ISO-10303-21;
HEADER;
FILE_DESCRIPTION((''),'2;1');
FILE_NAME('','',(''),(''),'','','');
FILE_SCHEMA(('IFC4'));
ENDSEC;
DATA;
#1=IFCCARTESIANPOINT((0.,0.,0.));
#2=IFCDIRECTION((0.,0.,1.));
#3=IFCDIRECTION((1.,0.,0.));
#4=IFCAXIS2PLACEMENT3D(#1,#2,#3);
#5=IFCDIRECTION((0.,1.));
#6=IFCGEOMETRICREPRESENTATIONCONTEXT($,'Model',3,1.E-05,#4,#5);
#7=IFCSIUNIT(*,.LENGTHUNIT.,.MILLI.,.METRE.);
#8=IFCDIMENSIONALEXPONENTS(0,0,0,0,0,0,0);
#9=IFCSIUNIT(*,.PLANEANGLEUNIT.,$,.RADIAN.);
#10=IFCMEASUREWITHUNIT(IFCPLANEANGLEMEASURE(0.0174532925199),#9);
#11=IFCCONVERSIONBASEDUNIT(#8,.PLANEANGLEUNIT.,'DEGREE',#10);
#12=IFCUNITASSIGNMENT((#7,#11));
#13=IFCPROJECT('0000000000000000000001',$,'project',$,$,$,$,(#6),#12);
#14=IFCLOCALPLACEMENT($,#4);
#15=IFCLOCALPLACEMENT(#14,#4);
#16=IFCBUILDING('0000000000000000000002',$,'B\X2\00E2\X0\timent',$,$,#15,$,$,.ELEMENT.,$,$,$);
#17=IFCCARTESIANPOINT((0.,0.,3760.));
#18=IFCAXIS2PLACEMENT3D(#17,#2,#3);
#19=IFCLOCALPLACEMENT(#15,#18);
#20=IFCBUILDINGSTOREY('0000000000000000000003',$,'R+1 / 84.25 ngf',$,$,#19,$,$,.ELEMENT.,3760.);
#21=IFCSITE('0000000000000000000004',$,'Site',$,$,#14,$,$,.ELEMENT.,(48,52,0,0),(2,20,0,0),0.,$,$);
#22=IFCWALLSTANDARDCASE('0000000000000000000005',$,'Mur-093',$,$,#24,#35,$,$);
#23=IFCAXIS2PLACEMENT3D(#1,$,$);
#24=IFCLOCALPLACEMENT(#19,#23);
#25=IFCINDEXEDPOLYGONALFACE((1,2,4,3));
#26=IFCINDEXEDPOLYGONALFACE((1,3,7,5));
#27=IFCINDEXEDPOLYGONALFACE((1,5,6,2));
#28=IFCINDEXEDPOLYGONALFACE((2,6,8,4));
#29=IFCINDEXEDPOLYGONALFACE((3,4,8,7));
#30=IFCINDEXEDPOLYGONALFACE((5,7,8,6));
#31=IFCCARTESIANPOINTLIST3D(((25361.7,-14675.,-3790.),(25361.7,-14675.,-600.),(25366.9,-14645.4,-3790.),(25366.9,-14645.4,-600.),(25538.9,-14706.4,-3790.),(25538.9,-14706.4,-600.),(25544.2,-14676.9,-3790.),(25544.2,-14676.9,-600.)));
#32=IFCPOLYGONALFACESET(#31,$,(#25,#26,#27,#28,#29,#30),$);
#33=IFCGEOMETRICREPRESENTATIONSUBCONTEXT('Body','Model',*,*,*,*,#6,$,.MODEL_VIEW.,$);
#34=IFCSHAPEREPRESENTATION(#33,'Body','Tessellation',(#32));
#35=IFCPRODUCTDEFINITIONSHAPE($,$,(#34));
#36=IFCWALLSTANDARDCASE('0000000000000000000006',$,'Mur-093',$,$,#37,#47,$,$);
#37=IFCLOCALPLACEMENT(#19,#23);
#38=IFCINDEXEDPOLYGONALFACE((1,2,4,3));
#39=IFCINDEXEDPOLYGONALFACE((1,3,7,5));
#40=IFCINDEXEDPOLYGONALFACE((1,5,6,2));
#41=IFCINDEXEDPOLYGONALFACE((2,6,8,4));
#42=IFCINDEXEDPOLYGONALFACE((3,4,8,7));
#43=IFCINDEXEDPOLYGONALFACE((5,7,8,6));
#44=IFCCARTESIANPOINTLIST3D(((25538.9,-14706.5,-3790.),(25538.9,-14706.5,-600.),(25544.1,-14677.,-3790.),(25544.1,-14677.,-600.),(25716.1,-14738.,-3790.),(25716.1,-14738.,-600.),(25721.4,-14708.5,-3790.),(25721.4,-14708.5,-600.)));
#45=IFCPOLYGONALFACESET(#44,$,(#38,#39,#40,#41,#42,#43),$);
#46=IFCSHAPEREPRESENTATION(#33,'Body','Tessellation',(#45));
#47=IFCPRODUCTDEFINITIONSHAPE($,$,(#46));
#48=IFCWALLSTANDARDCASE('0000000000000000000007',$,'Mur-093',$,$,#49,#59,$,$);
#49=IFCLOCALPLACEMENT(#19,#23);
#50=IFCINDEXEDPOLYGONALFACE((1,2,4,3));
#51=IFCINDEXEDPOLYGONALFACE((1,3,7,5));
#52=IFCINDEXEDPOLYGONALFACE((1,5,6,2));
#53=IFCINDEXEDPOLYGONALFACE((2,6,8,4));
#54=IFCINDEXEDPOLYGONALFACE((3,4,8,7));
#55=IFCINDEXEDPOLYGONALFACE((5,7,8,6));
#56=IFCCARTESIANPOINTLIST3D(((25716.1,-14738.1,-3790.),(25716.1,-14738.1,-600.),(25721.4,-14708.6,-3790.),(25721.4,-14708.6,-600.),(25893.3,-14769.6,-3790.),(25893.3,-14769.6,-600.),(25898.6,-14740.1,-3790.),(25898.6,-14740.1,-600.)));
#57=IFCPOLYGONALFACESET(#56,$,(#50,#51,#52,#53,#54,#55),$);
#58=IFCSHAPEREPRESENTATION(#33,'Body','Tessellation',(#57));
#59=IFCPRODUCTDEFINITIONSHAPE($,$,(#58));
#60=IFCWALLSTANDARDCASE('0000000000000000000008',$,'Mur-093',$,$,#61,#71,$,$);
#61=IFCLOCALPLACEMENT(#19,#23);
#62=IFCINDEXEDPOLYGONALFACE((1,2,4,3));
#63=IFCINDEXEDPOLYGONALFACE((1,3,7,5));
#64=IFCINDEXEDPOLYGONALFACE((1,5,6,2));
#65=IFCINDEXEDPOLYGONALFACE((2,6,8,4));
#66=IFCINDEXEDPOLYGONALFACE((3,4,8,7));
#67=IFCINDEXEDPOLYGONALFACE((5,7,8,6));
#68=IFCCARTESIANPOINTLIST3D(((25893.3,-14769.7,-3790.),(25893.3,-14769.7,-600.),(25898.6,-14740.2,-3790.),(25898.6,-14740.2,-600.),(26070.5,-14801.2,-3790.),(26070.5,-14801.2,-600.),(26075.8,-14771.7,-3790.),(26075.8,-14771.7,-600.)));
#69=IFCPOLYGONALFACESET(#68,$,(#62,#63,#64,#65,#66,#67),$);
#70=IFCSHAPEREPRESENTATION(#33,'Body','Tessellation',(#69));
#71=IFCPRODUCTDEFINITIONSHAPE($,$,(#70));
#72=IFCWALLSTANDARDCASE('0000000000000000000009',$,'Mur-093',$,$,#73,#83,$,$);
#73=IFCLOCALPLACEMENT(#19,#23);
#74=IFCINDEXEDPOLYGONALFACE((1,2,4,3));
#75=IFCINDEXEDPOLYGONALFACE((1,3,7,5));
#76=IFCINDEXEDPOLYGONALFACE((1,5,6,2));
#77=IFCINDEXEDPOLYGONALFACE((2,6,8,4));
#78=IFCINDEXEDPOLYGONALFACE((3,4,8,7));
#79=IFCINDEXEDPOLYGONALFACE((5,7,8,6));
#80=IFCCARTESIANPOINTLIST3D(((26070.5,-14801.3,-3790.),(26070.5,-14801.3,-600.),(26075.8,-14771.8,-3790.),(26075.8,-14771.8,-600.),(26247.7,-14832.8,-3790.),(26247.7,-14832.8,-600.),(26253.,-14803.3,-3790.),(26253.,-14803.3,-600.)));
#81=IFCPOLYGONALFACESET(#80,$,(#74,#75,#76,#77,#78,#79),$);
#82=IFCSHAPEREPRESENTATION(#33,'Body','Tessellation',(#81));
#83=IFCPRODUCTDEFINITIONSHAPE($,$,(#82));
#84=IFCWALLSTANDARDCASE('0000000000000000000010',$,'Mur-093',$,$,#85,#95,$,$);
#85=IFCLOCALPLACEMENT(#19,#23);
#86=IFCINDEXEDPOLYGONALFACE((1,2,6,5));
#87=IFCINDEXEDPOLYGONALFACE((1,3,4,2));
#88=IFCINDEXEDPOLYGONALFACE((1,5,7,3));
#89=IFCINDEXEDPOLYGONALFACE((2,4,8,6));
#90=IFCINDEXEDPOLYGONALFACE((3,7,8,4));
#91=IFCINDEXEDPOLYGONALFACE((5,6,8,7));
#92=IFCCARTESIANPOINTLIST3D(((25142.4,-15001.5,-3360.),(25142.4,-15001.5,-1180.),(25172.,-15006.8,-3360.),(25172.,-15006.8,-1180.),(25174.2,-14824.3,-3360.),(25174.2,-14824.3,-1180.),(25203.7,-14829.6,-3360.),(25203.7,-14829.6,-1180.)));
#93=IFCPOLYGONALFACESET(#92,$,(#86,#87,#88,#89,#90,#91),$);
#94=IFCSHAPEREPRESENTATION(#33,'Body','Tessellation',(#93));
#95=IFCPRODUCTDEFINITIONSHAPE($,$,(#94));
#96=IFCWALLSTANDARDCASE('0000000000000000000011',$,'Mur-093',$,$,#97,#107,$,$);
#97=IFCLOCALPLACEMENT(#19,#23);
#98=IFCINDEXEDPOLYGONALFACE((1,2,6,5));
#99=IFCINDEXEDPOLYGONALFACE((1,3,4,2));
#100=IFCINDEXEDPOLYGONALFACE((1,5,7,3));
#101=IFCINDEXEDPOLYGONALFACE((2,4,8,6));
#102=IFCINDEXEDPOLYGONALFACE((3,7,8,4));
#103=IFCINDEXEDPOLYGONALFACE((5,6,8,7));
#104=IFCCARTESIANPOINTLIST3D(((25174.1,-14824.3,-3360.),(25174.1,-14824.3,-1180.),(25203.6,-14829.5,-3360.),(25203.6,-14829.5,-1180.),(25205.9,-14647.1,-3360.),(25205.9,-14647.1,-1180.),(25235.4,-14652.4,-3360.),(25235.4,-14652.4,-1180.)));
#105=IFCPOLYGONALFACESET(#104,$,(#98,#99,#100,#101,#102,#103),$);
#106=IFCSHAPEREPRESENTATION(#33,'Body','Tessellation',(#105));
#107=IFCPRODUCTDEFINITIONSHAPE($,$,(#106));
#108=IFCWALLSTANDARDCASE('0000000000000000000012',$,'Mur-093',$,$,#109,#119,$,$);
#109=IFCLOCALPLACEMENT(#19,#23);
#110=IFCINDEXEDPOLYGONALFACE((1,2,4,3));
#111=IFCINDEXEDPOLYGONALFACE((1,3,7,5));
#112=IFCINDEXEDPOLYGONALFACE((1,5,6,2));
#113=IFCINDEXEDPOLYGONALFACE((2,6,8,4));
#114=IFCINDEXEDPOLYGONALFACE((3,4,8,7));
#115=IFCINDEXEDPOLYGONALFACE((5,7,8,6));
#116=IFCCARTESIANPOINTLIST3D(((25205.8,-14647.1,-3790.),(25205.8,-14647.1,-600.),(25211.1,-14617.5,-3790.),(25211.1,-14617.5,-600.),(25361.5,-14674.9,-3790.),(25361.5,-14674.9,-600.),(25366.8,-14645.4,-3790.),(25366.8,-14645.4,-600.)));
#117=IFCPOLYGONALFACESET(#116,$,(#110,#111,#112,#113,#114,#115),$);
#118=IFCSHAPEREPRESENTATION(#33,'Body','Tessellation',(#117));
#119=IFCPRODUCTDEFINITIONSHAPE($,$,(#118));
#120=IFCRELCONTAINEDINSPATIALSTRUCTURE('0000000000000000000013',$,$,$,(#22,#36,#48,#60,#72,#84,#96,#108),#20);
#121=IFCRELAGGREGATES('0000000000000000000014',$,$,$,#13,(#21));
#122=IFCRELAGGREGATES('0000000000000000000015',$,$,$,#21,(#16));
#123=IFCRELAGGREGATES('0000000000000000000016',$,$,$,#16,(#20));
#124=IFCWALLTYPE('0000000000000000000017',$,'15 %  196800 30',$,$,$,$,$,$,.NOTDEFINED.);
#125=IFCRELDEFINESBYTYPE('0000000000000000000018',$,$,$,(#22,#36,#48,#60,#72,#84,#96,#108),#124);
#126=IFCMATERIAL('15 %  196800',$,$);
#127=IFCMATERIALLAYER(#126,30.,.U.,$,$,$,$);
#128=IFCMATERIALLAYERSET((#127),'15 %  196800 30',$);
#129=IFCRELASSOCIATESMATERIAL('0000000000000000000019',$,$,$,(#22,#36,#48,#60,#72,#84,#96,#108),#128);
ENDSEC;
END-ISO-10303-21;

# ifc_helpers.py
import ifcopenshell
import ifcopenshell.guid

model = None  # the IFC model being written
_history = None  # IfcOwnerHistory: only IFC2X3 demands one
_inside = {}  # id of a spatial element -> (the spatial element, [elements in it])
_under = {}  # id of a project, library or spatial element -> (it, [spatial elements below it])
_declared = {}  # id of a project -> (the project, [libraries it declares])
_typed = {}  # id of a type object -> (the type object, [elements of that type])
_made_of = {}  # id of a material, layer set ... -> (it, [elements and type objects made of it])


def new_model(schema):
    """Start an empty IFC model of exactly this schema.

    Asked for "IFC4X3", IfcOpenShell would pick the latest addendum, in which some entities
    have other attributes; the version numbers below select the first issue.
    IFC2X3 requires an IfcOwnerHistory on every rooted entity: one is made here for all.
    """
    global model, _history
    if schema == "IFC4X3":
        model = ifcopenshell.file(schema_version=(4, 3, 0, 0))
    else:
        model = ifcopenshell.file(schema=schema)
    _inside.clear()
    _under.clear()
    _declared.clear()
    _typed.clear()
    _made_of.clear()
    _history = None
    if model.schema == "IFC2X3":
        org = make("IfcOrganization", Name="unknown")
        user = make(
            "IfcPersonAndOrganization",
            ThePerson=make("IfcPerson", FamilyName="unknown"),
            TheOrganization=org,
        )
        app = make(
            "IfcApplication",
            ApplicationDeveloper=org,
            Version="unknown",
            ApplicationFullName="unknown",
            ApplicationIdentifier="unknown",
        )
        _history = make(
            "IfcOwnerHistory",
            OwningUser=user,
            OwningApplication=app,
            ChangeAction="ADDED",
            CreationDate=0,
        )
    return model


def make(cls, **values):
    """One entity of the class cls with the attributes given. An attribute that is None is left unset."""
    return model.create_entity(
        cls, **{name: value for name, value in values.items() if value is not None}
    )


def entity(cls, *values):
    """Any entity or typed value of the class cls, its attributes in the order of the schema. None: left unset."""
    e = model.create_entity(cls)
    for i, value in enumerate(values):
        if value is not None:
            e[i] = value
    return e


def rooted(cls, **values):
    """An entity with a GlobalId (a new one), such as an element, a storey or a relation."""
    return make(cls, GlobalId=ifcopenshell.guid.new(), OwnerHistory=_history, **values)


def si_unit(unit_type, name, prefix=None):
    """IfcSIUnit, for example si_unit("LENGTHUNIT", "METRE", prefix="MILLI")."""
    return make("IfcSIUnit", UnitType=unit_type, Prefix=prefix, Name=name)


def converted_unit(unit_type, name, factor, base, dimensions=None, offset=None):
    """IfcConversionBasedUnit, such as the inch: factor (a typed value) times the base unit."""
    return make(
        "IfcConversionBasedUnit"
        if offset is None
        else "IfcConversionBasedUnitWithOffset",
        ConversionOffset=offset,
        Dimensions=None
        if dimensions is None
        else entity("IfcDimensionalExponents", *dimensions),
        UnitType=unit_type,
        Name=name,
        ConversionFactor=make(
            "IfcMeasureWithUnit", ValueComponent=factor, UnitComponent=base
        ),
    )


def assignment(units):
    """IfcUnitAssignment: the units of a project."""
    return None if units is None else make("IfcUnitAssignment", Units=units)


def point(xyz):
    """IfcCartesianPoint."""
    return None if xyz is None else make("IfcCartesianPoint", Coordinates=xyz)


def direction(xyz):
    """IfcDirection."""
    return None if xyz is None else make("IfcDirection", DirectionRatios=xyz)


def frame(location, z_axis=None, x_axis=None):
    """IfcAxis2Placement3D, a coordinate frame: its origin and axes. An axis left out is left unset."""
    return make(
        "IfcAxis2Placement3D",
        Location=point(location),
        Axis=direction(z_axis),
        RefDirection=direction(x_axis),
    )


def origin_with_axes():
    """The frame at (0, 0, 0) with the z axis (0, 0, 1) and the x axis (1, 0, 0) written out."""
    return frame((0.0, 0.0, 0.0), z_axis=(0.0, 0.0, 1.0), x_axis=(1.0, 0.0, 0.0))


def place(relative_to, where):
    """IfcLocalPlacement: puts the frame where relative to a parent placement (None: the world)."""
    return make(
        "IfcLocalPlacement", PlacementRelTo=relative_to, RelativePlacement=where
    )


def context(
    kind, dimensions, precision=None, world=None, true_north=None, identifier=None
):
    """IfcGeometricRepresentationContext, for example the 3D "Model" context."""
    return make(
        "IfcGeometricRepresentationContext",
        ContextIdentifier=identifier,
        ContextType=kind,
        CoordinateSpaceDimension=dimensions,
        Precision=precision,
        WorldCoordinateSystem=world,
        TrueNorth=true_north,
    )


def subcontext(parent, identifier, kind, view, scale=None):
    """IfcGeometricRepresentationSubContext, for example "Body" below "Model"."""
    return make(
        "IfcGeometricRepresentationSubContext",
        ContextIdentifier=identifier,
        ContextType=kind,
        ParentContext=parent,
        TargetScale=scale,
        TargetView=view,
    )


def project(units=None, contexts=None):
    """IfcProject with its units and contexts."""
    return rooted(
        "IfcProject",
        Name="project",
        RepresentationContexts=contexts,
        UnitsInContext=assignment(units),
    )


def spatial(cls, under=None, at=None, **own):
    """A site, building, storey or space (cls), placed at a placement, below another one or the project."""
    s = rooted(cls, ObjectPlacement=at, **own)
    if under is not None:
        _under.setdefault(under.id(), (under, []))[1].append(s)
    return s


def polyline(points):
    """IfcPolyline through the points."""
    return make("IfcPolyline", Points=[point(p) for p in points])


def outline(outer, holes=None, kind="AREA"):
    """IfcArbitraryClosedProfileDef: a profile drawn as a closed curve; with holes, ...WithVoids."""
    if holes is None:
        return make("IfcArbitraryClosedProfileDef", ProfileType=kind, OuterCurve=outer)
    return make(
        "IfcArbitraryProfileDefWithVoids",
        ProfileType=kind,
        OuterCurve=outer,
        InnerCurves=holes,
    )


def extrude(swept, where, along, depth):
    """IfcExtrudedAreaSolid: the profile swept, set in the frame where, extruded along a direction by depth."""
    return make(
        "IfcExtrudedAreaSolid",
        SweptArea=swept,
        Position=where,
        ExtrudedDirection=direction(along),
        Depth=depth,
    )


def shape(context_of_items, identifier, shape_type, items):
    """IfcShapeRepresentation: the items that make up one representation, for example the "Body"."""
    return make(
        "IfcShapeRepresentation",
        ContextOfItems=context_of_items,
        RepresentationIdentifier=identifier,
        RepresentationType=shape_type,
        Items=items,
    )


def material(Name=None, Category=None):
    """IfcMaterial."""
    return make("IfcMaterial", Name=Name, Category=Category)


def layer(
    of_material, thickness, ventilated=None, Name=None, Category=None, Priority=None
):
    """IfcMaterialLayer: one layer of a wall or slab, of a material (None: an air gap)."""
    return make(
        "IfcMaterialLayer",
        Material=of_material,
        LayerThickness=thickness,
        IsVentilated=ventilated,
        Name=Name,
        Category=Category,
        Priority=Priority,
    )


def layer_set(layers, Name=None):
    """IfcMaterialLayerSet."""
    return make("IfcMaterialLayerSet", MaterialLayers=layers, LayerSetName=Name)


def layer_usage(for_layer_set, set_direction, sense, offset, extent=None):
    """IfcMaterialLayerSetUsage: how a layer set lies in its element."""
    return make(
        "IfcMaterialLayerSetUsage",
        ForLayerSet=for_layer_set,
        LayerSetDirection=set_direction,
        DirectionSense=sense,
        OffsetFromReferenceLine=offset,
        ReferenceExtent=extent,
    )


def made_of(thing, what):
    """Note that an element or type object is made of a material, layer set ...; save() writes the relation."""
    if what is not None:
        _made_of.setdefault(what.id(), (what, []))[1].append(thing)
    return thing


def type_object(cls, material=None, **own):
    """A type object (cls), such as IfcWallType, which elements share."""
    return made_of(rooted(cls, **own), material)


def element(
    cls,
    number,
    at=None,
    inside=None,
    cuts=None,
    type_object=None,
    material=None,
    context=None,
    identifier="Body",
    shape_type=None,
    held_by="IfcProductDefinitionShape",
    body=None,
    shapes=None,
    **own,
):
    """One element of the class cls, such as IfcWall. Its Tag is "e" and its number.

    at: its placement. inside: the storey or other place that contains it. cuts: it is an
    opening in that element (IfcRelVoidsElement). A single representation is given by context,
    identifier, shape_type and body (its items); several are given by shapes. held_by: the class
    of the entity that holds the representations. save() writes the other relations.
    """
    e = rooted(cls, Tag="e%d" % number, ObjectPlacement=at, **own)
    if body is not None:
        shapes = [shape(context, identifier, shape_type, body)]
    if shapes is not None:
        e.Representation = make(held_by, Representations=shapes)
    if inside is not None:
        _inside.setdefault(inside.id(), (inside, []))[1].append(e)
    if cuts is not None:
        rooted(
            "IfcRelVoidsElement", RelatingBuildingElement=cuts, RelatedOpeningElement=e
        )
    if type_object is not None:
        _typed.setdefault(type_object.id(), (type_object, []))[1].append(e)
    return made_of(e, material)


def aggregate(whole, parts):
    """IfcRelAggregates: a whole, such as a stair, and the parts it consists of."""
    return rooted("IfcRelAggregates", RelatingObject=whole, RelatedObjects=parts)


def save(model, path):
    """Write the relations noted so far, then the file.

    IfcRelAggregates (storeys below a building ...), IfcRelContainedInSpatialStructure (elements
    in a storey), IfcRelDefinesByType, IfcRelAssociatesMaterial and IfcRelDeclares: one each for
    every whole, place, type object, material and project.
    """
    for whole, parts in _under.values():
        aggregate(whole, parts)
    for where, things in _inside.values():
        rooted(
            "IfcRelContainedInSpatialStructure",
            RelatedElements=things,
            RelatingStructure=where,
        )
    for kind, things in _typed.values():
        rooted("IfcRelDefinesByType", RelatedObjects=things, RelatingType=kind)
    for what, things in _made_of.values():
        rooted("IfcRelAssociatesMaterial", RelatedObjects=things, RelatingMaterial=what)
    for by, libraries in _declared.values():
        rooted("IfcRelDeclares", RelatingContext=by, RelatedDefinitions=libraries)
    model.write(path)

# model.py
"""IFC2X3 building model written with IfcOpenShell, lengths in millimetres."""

from ifc_helpers import new_model, entity, si_unit, converted_unit, direction, frame, origin_with_axes, place, context, subcontext, project, spatial, polyline, outline, extrude, material, layer, layer_set, layer_usage, type_object, element, save


model = new_model("IFC2X3")

# Units and contexts
model_context = context("Model", 3, precision=1e-05, world=origin_with_axes(), true_north=direction((0.0, 1.0)))
body_context = subcontext(model_context, "Body", "Model", "MODEL_VIEW")
ifc_project = project(units=[si_unit("LENGTHUNIT", "METRE", prefix="MILLI"), converted_unit("PLANEANGLEUNIT", "DEGREE", entity("IfcPlaneAngleMeasure", 0.0174532925199), si_unit("PLANEANGLEUNIT", "RADIAN"), dimensions=[0, 0, 0, 0, 0, 0, 0])], contexts=[model_context])

# Site, building, storey
site_placement = place(None, origin_with_axes())
site = spatial("IfcSite", under=ifc_project, at=site_placement, Name="Site", CompositionType="ELEMENT", RefLatitude=(48, 52, 0, 0), RefLongitude=(2, 20, 0, 0), RefElevation=0.0)
building_placement = place(site_placement, origin_with_axes())
building = spatial("IfcBuilding", under=site, at=building_placement, Name="Bâtiment", CompositionType="ELEMENT")
storey_placement = place(building_placement, frame((0.0, 0.0, 3760.0), z_axis=(0.0, 0.0, 1.0), x_axis=(1.0, 0.0, 0.0)))
storey = spatial("IfcBuildingStorey", under=building, at=storey_placement, Name="R+1 / 84.25 ngf", CompositionType="ELEMENT", Elevation=3760.0)

# Walls
ifc_material = material(Name="15 %  196800")
ifc_layer = layer(ifc_material, 30.0, ventilated="UNKNOWN")
ifc_layer_set = layer_set([ifc_layer], Name="15 %  196800 30")
wall_type = type_object("IfcWallType", Name="15 %  196800 30", PredefinedType="NOTDEFINED")
ifc_layer_usage_1 = layer_usage(ifc_layer_set, "AXIS2", "NEGATIVE", 30.0)
wall_1_placement = place(storey_placement, frame((25544.2, -14676.9, -3790.0), z_axis=(0.0, 0.0, 1.0), x_axis=(-0.984592, 0.174869, 0.0)))
element("IfcWallStandardCase", 1, at=wall_1_placement, inside=storey, type_object=wall_type, material=ifc_layer_usage_1, Name="Mur-093", context=body_context, shape_type="SweptSolid", body=[
    extrude(outline(polyline([(0.0, 0.0), (180.0, 0.0), (180.0, 30.0), (0.0, 30.0), (0.0, 0.0)])), origin_with_axes(), (0.0, 0.0, 1.0), 3190.0),
])
ifc_layer_usage_2 = layer_usage(ifc_layer_set, "AXIS2", "NEGATIVE", 30.0)
wall_2_placement = place(storey_placement, frame((25721.4, -14708.5, -3790.0), z_axis=(0.0, 0.0, 1.0), x_axis=(-0.984592, 0.174869, 0.0)))
element("IfcWallStandardCase", 2, at=wall_2_placement, inside=storey, type_object=wall_type, material=ifc_layer_usage_2, Name="Mur-093", context=body_context, shape_type="SweptSolid", body=[
    extrude(outline(polyline([(0.0, 0.0), (180.0, 0.0), (180.0, 30.0), (0.0, 30.0), (0.0, 0.0)])), origin_with_axes(), (0.0, 0.0, 1.0), 3190.0),
])
ifc_layer_usage_3 = layer_usage(ifc_layer_set, "AXIS2", "NEGATIVE", 30.0)
wall_3_placement = place(storey_placement, frame((25898.6, -14740.1, -3790.0), z_axis=(0.0, 0.0, 1.0), x_axis=(-0.984592, 0.174869, 0.0)))
element("IfcWallStandardCase", 3, at=wall_3_placement, inside=storey, type_object=wall_type, material=ifc_layer_usage_3, Name="Mur-093", context=body_context, shape_type="SweptSolid", body=[
    extrude(outline(polyline([(0.0, 0.0), (180.0, 0.0), (180.0, 30.0), (0.0, 30.0), (0.0, 0.0)])), origin_with_axes(), (0.0, 0.0, 1.0), 3190.0),
])
ifc_layer_usage_4 = layer_usage(ifc_layer_set, "AXIS2", "NEGATIVE", 30.0)
wall_4_placement = place(storey_placement, frame((26075.8, -14771.7, -3790.0), z_axis=(0.0, 0.0, 1.0), x_axis=(-0.984592, 0.174869, 0.0)))
element("IfcWallStandardCase", 4, at=wall_4_placement, inside=storey, type_object=wall_type, material=ifc_layer_usage_4, Name="Mur-093", context=body_context, shape_type="SweptSolid", body=[
    extrude(outline(polyline([(0.0, 0.0), (180.0, 0.0), (180.0, 30.0), (0.0, 30.0), (0.0, 0.0)])), origin_with_axes(), (0.0, 0.0, 1.0), 3190.0),
])
ifc_layer_usage_5 = layer_usage(ifc_layer_set, "AXIS2", "NEGATIVE", 30.0)
wall_5_placement = place(storey_placement, frame((26253.0, -14803.3, -3790.0), z_axis=(0.0, 0.0, 1.0), x_axis=(-0.984592, 0.174869, 0.0)))
element("IfcWallStandardCase", 5, at=wall_5_placement, inside=storey, type_object=wall_type, material=ifc_layer_usage_5, Name="Mur-093", context=body_context, shape_type="SweptSolid", body=[
    extrude(outline(polyline([(0.0, 0.0), (180.0, 0.0), (180.0, 30.0), (0.0, 30.0), (0.0, 0.0)])), origin_with_axes(), (0.0, 0.0, 1.0), 3190.0),
])
ifc_layer_usage_6 = layer_usage(ifc_layer_set, "AXIS2", "NEGATIVE", 30.0)
wall_6_placement = place(storey_placement, frame((25174.2, -14824.3, -3360.0), z_axis=(0.0, 0.0, 1.0), x_axis=(-0.176462, -0.984308, 0.0)))
element("IfcWallStandardCase", 6, at=wall_6_placement, inside=storey, type_object=wall_type, material=ifc_layer_usage_6, Name="Mur-093", context=body_context, shape_type="SweptSolid", body=[
    extrude(outline(polyline([(0.0, 0.0), (180.0, 0.0), (180.0, 30.0), (0.0, 30.0), (0.0, 0.0)])), origin_with_axes(), (0.0, 0.0, 1.0), 2180.0),
])
ifc_layer_usage_7 = layer_usage(ifc_layer_set, "AXIS2", "NEGATIVE", 30.0)
wall_7_placement = place(storey_placement, frame((25205.9, -14647.1, -3360.0), z_axis=(0.0, 0.0, 1.0), x_axis=(-0.176462, -0.984308, 0.0)))
element("IfcWallStandardCase", 7, at=wall_7_placement, inside=storey, type_object=wall_type, material=ifc_layer_usage_7, Name="Mur-093", context=body_context, shape_type="SweptSolid", body=[
    extrude(outline(polyline([(0.0, 0.0), (180.0, 0.0), (180.0, 30.0), (0.0, 30.0), (0.0, 0.0)])), origin_with_axes(), (0.0, 0.0, 1.0), 2180.0),
])
ifc_layer_usage_8 = layer_usage(ifc_layer_set, "AXIS2", "NEGATIVE", 30.0)
wall_8_placement = place(storey_placement, frame((25366.8, -14645.4, -3790.0), z_axis=(0.0, 0.0, 1.0), x_axis=(-0.984385, 0.176031, 0.0)))
element("IfcWallStandardCase", 8, at=wall_8_placement, inside=storey, type_object=wall_type, material=ifc_layer_usage_8, Name="Mur-093", context=body_context, shape_type="SweptSolid", body=[
    extrude(outline(polyline([(0.0, 0.0), (158.1, 0.0), (158.1, 30.0), (0.0, 30.0), (0.0, 0.0)])), origin_with_axes(), (0.0, 0.0, 1.0), 3190.0),
])

save(model, "model.ifc")
